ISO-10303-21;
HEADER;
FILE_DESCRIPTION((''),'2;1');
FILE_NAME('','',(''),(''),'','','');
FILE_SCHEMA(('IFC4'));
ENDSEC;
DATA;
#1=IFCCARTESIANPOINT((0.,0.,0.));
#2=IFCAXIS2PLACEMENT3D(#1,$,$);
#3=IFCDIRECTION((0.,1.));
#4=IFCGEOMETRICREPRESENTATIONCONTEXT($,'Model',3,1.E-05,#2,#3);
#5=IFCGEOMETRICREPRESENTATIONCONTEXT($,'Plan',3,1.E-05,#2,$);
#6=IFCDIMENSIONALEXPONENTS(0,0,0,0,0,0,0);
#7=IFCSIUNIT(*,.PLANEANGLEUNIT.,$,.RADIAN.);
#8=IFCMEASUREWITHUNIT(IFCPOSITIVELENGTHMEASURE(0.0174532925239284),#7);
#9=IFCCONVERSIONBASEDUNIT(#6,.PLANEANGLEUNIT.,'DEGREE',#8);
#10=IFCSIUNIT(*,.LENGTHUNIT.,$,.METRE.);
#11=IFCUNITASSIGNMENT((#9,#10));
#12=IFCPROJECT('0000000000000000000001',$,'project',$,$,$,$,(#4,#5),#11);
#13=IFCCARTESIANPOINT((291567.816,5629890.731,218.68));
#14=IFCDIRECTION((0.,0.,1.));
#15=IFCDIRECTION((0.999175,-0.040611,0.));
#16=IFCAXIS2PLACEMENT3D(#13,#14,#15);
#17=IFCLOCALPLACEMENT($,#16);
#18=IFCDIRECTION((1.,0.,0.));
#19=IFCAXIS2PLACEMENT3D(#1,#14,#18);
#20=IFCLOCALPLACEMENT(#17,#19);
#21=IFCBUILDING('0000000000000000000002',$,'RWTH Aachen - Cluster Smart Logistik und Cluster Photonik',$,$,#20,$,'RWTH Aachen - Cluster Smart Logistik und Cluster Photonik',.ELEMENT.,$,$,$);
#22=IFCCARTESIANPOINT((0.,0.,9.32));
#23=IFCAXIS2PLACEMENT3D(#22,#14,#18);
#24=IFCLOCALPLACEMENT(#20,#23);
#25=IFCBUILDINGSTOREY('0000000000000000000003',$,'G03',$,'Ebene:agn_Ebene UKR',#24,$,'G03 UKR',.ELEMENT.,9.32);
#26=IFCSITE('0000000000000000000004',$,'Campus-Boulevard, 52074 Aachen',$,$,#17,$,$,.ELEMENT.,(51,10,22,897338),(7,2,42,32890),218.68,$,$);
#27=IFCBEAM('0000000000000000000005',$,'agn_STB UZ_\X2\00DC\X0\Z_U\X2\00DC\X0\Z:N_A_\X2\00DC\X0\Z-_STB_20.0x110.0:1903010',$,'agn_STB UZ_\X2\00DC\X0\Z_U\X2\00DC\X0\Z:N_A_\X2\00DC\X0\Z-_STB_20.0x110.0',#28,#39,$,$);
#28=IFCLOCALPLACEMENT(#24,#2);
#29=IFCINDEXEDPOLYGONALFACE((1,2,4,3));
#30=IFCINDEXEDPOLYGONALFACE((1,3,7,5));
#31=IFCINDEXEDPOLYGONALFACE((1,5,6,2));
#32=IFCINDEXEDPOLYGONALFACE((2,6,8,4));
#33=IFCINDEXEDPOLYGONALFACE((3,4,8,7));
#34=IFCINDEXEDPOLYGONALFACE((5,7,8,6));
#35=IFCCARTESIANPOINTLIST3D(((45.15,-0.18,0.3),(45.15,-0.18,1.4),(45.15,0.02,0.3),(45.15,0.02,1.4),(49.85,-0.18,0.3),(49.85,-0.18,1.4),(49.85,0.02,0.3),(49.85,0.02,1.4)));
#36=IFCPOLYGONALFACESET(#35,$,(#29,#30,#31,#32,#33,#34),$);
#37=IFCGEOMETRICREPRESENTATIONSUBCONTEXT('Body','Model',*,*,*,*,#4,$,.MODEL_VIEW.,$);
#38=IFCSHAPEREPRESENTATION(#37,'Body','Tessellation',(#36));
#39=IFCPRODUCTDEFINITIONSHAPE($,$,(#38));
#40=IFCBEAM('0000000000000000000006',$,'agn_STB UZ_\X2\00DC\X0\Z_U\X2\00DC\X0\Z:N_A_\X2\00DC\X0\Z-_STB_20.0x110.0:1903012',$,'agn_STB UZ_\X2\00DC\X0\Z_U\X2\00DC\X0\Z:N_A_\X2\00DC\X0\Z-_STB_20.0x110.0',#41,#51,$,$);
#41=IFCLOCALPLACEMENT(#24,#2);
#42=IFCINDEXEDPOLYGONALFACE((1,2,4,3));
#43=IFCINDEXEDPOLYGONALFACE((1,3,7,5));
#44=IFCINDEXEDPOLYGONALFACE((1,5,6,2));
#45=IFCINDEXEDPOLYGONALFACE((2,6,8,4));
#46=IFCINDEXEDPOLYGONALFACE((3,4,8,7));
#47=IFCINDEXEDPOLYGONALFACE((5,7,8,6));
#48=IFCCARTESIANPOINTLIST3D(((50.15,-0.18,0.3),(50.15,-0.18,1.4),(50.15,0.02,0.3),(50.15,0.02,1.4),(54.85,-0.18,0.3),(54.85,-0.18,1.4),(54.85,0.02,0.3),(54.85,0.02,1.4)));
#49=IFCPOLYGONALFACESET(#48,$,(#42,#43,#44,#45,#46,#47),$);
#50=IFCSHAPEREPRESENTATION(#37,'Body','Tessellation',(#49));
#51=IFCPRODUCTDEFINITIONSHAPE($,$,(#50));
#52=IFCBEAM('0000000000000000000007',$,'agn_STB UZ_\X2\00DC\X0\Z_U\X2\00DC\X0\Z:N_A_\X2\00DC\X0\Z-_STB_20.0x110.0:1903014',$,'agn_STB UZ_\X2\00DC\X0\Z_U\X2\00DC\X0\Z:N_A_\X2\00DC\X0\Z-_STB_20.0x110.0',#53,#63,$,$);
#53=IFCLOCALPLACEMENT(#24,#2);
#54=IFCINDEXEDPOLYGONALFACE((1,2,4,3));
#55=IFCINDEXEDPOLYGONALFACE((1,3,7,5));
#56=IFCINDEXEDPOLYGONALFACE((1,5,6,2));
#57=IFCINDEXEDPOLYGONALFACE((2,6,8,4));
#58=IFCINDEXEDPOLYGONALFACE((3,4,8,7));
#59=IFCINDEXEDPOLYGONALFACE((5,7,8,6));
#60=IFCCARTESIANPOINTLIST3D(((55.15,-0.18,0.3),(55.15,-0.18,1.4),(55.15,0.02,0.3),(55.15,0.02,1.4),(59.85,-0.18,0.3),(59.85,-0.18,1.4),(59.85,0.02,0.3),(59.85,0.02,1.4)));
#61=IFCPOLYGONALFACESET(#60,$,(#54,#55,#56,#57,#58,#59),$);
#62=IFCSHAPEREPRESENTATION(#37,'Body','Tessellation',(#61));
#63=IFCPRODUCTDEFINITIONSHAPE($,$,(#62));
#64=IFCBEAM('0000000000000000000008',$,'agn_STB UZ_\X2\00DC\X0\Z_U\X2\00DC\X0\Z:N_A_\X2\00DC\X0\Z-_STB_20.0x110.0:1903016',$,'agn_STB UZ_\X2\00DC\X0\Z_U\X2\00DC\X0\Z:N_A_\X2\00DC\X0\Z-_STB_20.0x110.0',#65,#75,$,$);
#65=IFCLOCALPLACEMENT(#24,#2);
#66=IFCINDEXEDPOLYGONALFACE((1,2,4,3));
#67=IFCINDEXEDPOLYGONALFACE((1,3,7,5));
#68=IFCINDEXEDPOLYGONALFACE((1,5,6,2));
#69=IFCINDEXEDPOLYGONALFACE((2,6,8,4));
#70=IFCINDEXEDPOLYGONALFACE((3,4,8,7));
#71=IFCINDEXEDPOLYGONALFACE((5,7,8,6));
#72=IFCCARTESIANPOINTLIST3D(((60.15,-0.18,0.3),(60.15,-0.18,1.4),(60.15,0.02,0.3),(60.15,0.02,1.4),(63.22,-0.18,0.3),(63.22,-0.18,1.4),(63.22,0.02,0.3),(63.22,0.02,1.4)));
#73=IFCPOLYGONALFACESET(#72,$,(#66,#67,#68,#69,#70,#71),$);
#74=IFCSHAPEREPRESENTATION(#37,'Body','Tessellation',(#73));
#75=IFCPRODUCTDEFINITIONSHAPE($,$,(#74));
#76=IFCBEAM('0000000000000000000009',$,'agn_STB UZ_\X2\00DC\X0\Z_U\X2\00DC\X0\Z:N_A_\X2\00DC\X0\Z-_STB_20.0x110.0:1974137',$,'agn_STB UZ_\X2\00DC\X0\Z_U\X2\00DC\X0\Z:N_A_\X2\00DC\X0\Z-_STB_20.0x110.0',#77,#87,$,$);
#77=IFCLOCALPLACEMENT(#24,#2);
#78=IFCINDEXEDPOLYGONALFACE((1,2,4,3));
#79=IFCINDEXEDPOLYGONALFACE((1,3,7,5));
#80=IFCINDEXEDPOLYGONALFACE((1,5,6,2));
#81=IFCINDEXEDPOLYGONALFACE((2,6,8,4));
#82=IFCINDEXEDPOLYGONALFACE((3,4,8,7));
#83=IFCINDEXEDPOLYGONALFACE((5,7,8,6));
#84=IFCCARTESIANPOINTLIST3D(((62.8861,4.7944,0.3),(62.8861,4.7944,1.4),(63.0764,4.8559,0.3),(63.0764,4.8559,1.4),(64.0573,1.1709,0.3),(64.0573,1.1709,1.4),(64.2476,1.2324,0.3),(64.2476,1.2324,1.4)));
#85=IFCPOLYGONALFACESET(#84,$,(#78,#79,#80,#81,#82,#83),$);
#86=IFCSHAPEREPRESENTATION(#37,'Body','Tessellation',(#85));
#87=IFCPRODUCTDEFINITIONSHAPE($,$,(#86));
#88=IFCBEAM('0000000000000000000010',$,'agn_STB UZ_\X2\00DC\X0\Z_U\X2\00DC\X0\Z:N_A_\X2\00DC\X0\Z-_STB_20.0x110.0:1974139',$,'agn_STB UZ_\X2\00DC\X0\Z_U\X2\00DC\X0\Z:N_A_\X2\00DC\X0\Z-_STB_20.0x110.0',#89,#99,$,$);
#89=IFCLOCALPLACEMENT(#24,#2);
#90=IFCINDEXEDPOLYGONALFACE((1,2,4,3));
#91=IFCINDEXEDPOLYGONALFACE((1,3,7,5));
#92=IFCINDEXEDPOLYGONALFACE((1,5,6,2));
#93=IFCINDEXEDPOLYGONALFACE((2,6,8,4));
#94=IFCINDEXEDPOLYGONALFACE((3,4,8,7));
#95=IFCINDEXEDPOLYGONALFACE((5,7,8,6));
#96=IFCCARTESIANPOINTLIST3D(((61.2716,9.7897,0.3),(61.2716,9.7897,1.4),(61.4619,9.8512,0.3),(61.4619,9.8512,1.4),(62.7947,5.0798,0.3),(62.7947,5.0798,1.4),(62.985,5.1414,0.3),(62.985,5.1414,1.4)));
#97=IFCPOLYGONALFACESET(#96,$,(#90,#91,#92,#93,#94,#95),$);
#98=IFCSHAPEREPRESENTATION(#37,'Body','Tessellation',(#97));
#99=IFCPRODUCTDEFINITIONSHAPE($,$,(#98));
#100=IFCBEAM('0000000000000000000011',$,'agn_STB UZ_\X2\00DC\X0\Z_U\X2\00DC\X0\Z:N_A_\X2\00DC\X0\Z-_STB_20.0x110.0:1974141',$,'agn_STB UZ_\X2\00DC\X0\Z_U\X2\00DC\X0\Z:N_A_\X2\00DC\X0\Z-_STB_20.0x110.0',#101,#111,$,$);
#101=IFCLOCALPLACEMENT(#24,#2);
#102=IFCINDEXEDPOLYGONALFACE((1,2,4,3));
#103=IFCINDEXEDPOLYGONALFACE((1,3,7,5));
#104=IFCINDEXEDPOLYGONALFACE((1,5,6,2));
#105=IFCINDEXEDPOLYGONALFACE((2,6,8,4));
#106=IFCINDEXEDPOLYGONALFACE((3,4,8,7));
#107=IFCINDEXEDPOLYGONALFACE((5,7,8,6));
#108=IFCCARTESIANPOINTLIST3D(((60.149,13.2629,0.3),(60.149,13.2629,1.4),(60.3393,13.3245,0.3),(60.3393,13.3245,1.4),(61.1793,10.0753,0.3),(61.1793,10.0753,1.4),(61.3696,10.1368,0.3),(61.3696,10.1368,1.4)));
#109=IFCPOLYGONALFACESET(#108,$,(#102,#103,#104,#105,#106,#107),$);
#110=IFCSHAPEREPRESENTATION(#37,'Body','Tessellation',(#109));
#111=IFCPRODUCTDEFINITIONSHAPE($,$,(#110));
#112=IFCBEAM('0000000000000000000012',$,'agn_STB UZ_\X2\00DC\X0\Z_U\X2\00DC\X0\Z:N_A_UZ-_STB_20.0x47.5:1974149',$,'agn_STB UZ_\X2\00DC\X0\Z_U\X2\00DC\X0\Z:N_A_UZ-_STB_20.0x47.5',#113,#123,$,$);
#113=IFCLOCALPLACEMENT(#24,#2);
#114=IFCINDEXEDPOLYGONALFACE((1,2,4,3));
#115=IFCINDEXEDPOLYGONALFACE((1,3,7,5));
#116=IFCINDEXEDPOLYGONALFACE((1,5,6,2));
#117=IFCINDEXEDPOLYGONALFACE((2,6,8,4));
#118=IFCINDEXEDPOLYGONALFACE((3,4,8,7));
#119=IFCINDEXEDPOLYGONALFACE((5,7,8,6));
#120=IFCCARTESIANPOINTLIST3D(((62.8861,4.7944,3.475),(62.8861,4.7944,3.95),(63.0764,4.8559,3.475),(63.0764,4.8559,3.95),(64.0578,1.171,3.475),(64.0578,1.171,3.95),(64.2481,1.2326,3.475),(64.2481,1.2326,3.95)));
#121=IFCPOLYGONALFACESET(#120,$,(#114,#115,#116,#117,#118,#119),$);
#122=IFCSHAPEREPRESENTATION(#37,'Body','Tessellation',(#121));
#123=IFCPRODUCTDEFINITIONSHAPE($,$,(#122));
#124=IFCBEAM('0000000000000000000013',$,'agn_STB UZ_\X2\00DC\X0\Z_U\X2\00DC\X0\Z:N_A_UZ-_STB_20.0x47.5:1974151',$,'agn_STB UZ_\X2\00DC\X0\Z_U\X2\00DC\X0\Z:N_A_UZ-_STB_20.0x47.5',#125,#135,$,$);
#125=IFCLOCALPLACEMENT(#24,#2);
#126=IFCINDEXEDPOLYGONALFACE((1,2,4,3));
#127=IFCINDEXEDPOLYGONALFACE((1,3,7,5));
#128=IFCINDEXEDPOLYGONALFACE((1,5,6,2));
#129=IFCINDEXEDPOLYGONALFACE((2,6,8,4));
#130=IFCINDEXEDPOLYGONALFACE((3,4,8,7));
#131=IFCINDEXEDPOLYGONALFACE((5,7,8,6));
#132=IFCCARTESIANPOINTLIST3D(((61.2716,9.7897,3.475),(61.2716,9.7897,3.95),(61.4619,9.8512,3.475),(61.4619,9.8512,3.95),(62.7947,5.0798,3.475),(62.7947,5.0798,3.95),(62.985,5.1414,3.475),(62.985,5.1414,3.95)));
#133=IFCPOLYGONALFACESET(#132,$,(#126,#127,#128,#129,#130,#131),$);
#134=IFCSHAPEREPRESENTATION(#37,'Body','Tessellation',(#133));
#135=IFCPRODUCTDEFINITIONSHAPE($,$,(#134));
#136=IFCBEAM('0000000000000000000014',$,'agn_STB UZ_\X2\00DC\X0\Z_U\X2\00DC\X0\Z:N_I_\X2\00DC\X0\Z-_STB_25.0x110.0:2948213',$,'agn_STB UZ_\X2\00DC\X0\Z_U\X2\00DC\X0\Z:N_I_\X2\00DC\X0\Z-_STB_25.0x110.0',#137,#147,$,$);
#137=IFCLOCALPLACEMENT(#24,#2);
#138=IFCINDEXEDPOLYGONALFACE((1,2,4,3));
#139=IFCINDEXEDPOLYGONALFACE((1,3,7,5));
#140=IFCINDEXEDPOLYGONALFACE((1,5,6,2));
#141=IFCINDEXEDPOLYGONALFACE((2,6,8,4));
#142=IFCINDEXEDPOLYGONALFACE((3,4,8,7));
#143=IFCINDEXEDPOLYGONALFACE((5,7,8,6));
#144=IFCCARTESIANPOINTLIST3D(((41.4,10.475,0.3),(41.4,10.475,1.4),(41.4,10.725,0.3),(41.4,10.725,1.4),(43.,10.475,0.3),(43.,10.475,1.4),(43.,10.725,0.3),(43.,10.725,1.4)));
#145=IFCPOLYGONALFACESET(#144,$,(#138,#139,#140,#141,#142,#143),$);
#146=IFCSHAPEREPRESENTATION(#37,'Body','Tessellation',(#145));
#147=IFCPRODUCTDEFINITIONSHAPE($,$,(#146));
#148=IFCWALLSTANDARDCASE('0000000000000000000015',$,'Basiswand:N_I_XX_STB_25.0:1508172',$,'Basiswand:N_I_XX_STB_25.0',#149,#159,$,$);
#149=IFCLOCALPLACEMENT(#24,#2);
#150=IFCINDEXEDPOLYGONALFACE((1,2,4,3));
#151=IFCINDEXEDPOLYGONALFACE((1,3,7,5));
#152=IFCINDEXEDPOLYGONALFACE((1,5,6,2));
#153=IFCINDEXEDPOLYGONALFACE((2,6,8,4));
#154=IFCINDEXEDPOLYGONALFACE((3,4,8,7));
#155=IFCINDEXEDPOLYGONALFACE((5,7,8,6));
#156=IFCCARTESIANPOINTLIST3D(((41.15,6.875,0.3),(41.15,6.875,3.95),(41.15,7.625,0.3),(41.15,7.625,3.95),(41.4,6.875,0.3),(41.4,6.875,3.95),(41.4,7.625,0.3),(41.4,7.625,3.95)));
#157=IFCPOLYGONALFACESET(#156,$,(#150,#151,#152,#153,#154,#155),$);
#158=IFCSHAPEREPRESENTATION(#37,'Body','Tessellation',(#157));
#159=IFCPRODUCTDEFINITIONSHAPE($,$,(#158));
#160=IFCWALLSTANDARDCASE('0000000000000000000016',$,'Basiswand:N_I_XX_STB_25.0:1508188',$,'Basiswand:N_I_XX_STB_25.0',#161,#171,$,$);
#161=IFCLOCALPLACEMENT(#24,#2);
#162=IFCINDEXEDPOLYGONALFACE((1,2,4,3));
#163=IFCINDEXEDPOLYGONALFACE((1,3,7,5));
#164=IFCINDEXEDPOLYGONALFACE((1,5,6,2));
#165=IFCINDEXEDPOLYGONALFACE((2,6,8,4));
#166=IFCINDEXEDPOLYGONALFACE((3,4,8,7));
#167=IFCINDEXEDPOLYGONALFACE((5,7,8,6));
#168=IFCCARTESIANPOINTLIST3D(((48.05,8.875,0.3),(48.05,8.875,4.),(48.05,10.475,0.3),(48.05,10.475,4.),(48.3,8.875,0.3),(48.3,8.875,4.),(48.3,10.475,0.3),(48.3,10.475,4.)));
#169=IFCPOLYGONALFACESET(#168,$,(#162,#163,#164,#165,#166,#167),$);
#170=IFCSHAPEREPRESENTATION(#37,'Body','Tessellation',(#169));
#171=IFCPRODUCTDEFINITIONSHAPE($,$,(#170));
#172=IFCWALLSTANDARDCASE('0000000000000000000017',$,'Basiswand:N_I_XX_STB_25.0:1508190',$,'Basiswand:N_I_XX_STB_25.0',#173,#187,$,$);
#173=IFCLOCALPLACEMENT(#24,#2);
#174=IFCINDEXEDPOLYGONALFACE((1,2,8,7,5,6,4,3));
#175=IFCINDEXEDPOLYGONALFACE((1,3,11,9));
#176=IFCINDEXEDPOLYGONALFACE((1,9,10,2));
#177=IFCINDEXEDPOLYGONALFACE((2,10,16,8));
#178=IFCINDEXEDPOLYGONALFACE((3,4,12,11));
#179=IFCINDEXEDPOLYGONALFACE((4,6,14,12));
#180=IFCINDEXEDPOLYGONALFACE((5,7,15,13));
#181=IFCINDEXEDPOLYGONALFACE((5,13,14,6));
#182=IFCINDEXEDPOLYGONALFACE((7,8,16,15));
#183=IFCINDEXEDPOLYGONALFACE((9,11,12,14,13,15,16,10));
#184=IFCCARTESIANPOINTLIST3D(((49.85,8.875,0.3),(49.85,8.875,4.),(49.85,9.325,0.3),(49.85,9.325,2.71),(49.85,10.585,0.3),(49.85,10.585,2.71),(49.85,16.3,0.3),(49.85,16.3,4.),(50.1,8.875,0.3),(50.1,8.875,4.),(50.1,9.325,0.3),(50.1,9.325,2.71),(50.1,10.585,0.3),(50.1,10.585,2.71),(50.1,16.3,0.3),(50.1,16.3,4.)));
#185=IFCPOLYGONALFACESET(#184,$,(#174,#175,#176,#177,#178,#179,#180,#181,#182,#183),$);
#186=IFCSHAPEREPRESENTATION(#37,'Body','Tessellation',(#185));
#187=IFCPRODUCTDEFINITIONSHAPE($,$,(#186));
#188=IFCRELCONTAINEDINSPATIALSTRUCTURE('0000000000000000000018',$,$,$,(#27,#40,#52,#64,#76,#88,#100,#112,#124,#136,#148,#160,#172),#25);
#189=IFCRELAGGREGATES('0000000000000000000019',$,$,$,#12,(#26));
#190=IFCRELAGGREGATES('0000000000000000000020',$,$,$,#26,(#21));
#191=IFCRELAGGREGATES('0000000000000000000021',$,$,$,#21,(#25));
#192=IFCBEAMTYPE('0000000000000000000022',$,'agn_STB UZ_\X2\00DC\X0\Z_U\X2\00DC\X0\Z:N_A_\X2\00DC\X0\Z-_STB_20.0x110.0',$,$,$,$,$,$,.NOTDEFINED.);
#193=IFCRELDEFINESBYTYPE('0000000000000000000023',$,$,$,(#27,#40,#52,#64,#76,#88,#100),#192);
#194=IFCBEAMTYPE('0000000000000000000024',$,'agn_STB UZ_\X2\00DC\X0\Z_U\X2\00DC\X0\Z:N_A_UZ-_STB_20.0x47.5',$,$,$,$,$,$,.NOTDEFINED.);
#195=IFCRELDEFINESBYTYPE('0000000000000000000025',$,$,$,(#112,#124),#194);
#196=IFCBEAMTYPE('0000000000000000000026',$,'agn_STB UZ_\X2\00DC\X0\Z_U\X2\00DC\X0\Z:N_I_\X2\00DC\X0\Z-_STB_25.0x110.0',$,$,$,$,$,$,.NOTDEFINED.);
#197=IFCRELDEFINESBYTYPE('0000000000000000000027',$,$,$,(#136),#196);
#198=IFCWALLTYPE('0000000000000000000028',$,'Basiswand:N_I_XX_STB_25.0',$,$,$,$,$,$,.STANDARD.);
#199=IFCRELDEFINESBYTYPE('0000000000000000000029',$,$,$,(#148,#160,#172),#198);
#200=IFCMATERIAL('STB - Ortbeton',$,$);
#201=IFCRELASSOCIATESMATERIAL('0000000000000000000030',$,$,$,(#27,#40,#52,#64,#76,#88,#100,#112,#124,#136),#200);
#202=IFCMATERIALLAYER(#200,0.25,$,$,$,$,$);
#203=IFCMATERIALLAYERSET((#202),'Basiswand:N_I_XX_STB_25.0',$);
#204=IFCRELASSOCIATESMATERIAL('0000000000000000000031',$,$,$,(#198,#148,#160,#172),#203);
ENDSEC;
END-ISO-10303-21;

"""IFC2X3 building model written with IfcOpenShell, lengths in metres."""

from ifc_helpers import new_model, entity, si_unit, converted_unit, direction, frame, frame_2d, origin, origin_with_axes, place, context, subcontext, project, spatial, rectangle, extrude, material, layer, layer_set, layer_usage, type_object, element, save


model = new_model("IFC2X3")

# Units and contexts
model_context = context("Model", 3, precision=1e-05, world=origin(), true_north=direction((0.0, 1.0)))
plan_context = context("Plan", 3, precision=1e-05, world=origin())
body_context = subcontext(model_context, "Body", "Model", "MODEL_VIEW")
ifc_project = project(units=[converted_unit("PLANEANGLEUNIT", "DEGREE", entity("IfcPositiveLengthMeasure", 0.0174532925239284), si_unit("PLANEANGLEUNIT", "RADIAN"), dimensions=[0, 0, 0, 0, 0, 0, 0]), si_unit("LENGTHUNIT", "METRE")], contexts=[model_context, plan_context])

# Site, building, storey
site_placement = place(None, frame((291567.816, 5629890.731, 218.68), z_axis=(0.0, 0.0, 1.0), x_axis=(0.999175, -0.040611, 0.0)))
site = spatial("IfcSite", under=ifc_project, at=site_placement, Name="Campus-Boulevard, 52074 Aachen", CompositionType="ELEMENT", RefLatitude=(51, 10, 22, 897338), RefLongitude=(7, 2, 42, 32890), RefElevation=218.68)
building_placement = place(site_placement, origin_with_axes())
building = spatial("IfcBuilding", under=site, at=building_placement, Name="RWTH Aachen - Cluster Smart Logistik und Cluster Photonik", LongName="RWTH Aachen - Cluster Smart Logistik und Cluster Photonik", CompositionType="ELEMENT")
storey_placement = place(building_placement, frame((0.0, 0.0, 9.32), z_axis=(0.0, 0.0, 1.0), x_axis=(1.0, 0.0, 0.0)))
storey = spatial("IfcBuildingStorey", under=building, at=storey_placement, Name="G03", ObjectType="Ebene:agn_Ebene UKR", LongName="G03 UKR", CompositionType="ELEMENT", Elevation=9.32)

# Beams
ifc_material_1 = material(Name="STB - Ortbeton")
beam_type_1 = type_object("IfcBeamType", Name="agn_STB UZ_ÜZ_UÜZ:N_A_ÜZ-_STB_20.0x110.0", PredefinedType="NOTDEFINED")
for number, where, z_axis, x_axis, name in (
    (1, (45.15, -0.08, 0.3), (0.0, 0.0, 1.0), (1.0, 0.0, 0.0), "agn_STB UZ_ÜZ_UÜZ:N_A_ÜZ-_STB_20.0x110.0:1903010"),
    (2, (50.15, -0.08, 0.3), (0.0, 0.0, 1.0), (1.0, 0.0, 0.0), "agn_STB UZ_ÜZ_UÜZ:N_A_ÜZ-_STB_20.0x110.0:1903012"),
    (3, (55.15, -0.08, 0.3), (0.0, 0.0, 1.0), (1.0, 0.0, 0.0), "agn_STB UZ_ÜZ_UÜZ:N_A_ÜZ-_STB_20.0x110.0:1903014"),
):
    element("IfcBeam", number, at=place(storey_placement, frame(where, z_axis=z_axis, x_axis=x_axis)), inside=storey, type_object=beam_type_1, material=ifc_material_1, Name=name, ObjectType="agn_STB UZ_ÜZ_UÜZ:N_A_ÜZ-_STB_20.0x110.0", context=body_context, shape_type="SweptSolid", body=[
        extrude(rectangle(XDim=1.1, YDim=0.2, at=frame_2d((0.0, 0.0), x_axis=(1.0, 0.0))), frame((0.0, 0.0, 0.55), z_axis=(1.0, 0.0, 0.0), x_axis=(0.0, 0.0, -1.0)), (0.0, 0.0, 1.0), 4.7),
    ])
beam_1_placement = place(storey_placement, frame((60.15, -0.08, 0.3), z_axis=(0.0, 0.0, 1.0), x_axis=(1.0, 0.0, 0.0)))
element("IfcBeam", 4, at=beam_1_placement, inside=storey, type_object=beam_type_1, material=ifc_material_1, Name="agn_STB UZ_ÜZ_UÜZ:N_A_ÜZ-_STB_20.0x110.0:1903016", ObjectType="agn_STB UZ_ÜZ_UÜZ:N_A_ÜZ-_STB_20.0x110.0", context=body_context, shape_type="SweptSolid", body=[
    extrude(rectangle(XDim=1.1, YDim=0.2, at=frame_2d((0.0, 0.0), x_axis=(1.0, 0.0))), frame((0.0, 0.0, 0.55), z_axis=(1.0, 0.0, 0.0), x_axis=(0.0, 0.0, -1.0)), (0.0, 0.0, 1.0), 3.07),
])
beam_2_placement = place(storey_placement, frame((62.9812, 4.8253, 0.3), z_axis=(0.0, 0.0, 1.0), x_axis=(0.307546, -0.951533, 0.0)))
element("IfcBeam", 5, at=beam_2_placement, inside=storey, type_object=beam_type_1, material=ifc_material_1, Name="agn_STB UZ_ÜZ_UÜZ:N_A_ÜZ-_STB_20.0x110.0:1974137", ObjectType="agn_STB UZ_ÜZ_UÜZ:N_A_ÜZ-_STB_20.0x110.0", context=body_context, shape_type="SweptSolid", body=[
    extrude(rectangle(XDim=1.1, YDim=0.2, at=frame_2d((0.0, 0.0), x_axis=(1.0, 0.0))), frame((0.0001, 0.0, 0.55), z_axis=(1.0, 0.0, 0.0), x_axis=(0.0, 0.0, -1.0)), (0.0, 0.0, 1.0), 3.8081),
])
beam_3_placement = place(storey_placement, frame((61.3667, 9.8206, 0.3), z_axis=(0.0, 0.0, 1.0), x_axis=(0.307689, -0.951487, 0.0)))
element("IfcBeam", 6, at=beam_3_placement, inside=storey, type_object=beam_type_1, material=ifc_material_1, Name="agn_STB UZ_ÜZ_UÜZ:N_A_ÜZ-_STB_20.0x110.0:1974139", ObjectType="agn_STB UZ_ÜZ_UÜZ:N_A_ÜZ-_STB_20.0x110.0", context=body_context, shape_type="SweptSolid", body=[
    extrude(rectangle(XDim=1.1, YDim=0.2, at=frame_2d((0.0, 0.0), x_axis=(1.0, 0.0))), frame((0.0002, 0.0, 0.55), z_axis=(1.0, 0.0, 0.0), x_axis=(0.0, 0.0, -1.0)), (0.0, 0.0, 1.0), 4.95),
])
beam_4_placement = place(storey_placement, frame((60.2441, 13.294, 0.3), z_axis=(0.0, 0.0, 1.0), x_axis=(0.307544, -0.951534, 0.0)))
element("IfcBeam", 7, at=beam_4_placement, inside=storey, type_object=beam_type_1, material=ifc_material_1, Name="agn_STB UZ_ÜZ_UÜZ:N_A_ÜZ-_STB_20.0x110.0:1974141", ObjectType="agn_STB UZ_ÜZ_UÜZ:N_A_ÜZ-_STB_20.0x110.0", context=body_context, shape_type="SweptSolid", body=[
    extrude(rectangle(XDim=1.1, YDim=0.2, at=frame_2d((0.0, 0.0), x_axis=(1.0, 0.0))), frame((0.0003, 0.0, 0.55), z_axis=(1.0, 0.0, 0.0), x_axis=(0.0, 0.0, -1.0)), (0.0, 0.0, 1.0), 3.35),
])
beam_type_2 = type_object("IfcBeamType", Name="agn_STB UZ_ÜZ_UÜZ:N_A_UZ-_STB_20.0x47.5", PredefinedType="NOTDEFINED")
beam_5_placement = place(storey_placement, frame((62.9812, 4.8253, 0.3), z_axis=(0.0, 0.0, 1.0), x_axis=(0.307689, -0.951487, 0.0)))
element("IfcBeam", 8, at=beam_5_placement, inside=storey, type_object=beam_type_2, material=ifc_material_1, Name="agn_STB UZ_ÜZ_UÜZ:N_A_UZ-_STB_20.0x47.5:1974149", ObjectType="agn_STB UZ_ÜZ_UÜZ:N_A_UZ-_STB_20.0x47.5", context=body_context, shape_type="SweptSolid", body=[
    extrude(rectangle(XDim=0.475, YDim=0.2, at=frame_2d((0.0, 0.0), x_axis=(1.0, 0.0))), frame((0.0001, 0.0, 3.4125), z_axis=(1.0, 0.0, 0.0), x_axis=(0.0, 0.0, -1.0)), (0.0, 0.0, 1.0), 3.8081),
])
beam_6_placement = place(storey_placement, frame((61.3667, 9.8206, 0.3), z_axis=(0.0, 0.0, 1.0), x_axis=(0.307689, -0.951487, 0.0)))
element("IfcBeam", 9, at=beam_6_placement, inside=storey, type_object=beam_type_2, material=ifc_material_1, Name="agn_STB UZ_ÜZ_UÜZ:N_A_UZ-_STB_20.0x47.5:1974151", ObjectType="agn_STB UZ_ÜZ_UÜZ:N_A_UZ-_STB_20.0x47.5", context=body_context, shape_type="SweptSolid", body=[
    extrude(rectangle(XDim=0.475, YDim=0.2, at=frame_2d((0.0, 0.0), x_axis=(1.0, 0.0))), frame((0.0002, 0.0, 3.4125), z_axis=(1.0, 0.0, 0.0), x_axis=(0.0, 0.0, -1.0)), (0.0, 0.0, 1.0), 4.95),
])
beam_type_3 = type_object("IfcBeamType", Name="agn_STB UZ_ÜZ_UÜZ:N_I_ÜZ-_STB_25.0x110.0", PredefinedType="NOTDEFINED")
beam_7_placement = place(storey_placement, frame((43.1, 10.6, 0.3), z_axis=(0.0, 0.0, 1.0), x_axis=(-1.0, 0.0, 0.0)))
element("IfcBeam", 10, at=beam_7_placement, inside=storey, type_object=beam_type_3, material=ifc_material_1, Name="agn_STB UZ_ÜZ_UÜZ:N_I_ÜZ-_STB_25.0x110.0:2948213", ObjectType="agn_STB UZ_ÜZ_UÜZ:N_I_ÜZ-_STB_25.0x110.0", context=body_context, shape_type="SweptSolid", body=[
    extrude(rectangle(XDim=1.1, YDim=0.25, at=frame_2d((0.0, 0.0), x_axis=(1.0, 0.0))), frame((0.1, 0.0, 0.55), z_axis=(1.0, 0.0, 0.0), x_axis=(0.0, 0.0, -1.0)), (0.0, 0.0, 1.0), 1.6),
])

# Walls
ifc_layer_1 = layer(ifc_material_1, 0.25)
ifc_layer_set_1 = layer_set([ifc_layer_1], Name="Basiswand:N_I_XX_STB_25.0")
ifc_layer_usage_1 = layer_usage(ifc_layer_set_1, "AXIS2", "NEGATIVE", 0.125)
wall_type_1 = type_object("IfcWallType", Name="Basiswand:N_I_XX_STB_25.0", PredefinedType="STANDARD", material=ifc_layer_set_1)
wall_1_placement = place(storey_placement, frame((41.275, 6.875, 0.3), z_axis=(0.0, 0.0, 1.0), x_axis=(0.0, 1.0, 0.0)))
element("IfcWallStandardCase", 11, at=wall_1_placement, inside=storey, type_object=wall_type_1, material=ifc_layer_usage_1, Name="Basiswand:N_I_XX_STB_25.0:1508172", ObjectType="Basiswand:N_I_XX_STB_25.0", context=body_context, shape_type="SweptSolid", body=[
    extrude(rectangle(XDim=0.75, YDim=0.25, at=frame_2d((0.375, 0.0), x_axis=(-1.0, 0.0))), origin(), (0.0, 0.0, 1.0), 3.65),
])
ifc_layer_usage_2 = layer_usage(ifc_layer_set_1, "AXIS2", "NEGATIVE", 0.125)
wall_2_placement = place(storey_placement, frame((48.175, 8.875, 0.3), z_axis=(0.0, 0.0, 1.0), x_axis=(0.0, 1.0, 0.0)))
element("IfcWallStandardCase", 12, at=wall_2_placement, inside=storey, type_object=wall_type_1, material=ifc_layer_usage_2, Name="Basiswand:N_I_XX_STB_25.0:1508188", ObjectType="Basiswand:N_I_XX_STB_25.0", context=body_context, shape_type="SweptSolid", body=[
    extrude(rectangle(XDim=1.6, YDim=0.25, at=frame_2d((0.8, 0.0), x_axis=(-1.0, 0.0))), origin(), (0.0, 0.0, 1.0), 3.7),
])

# Wall, opening
ifc_layer_usage_3 = layer_usage(ifc_layer_set_1, "AXIS2", "NEGATIVE", 0.125)
wall_3_placement = place(storey_placement, frame((49.975, 8.875, 0.3), z_axis=(0.0, 0.0, 1.0), x_axis=(0.0, 1.0, 0.0)))
wall_3 = element("IfcWallStandardCase", 13, at=wall_3_placement, inside=storey, type_object=wall_type_1, material=ifc_layer_usage_3, Name="Basiswand:N_I_XX_STB_25.0:1508190", ObjectType="Basiswand:N_I_XX_STB_25.0", context=body_context, shape_type="SweptSolid", body=[
    extrude(rectangle(XDim=7.425, YDim=0.25, at=frame_2d((3.7125, 0.0), x_axis=(-1.0, 0.0))), origin(), (0.0, 0.0, 1.0), 3.7),
])
opening_placement = place(wall_3_placement, frame((0.45, -0.125, 0.0), z_axis=(0.0, 0.0, 1.0), x_axis=(1.0, 0.0, 0.0)))
element("IfcOpeningElement", 14, at=opening_placement, cuts=wall_3, ObjectType="Opening", context=body_context, shape_type="SweptSolid", body=[
    extrude(rectangle(XDim=2.41, YDim=1.26, at=frame_2d((1.205, 0.63), x_axis=(1.0, 0.0))), frame((0.0, 0.0, 0.0), z_axis=(0.0, 1.0, 0.0), x_axis=(0.0, 0.0, 1.0)), (0.0, 0.0, 1.0), 0.25),
])

save(model, "model.ifc")
